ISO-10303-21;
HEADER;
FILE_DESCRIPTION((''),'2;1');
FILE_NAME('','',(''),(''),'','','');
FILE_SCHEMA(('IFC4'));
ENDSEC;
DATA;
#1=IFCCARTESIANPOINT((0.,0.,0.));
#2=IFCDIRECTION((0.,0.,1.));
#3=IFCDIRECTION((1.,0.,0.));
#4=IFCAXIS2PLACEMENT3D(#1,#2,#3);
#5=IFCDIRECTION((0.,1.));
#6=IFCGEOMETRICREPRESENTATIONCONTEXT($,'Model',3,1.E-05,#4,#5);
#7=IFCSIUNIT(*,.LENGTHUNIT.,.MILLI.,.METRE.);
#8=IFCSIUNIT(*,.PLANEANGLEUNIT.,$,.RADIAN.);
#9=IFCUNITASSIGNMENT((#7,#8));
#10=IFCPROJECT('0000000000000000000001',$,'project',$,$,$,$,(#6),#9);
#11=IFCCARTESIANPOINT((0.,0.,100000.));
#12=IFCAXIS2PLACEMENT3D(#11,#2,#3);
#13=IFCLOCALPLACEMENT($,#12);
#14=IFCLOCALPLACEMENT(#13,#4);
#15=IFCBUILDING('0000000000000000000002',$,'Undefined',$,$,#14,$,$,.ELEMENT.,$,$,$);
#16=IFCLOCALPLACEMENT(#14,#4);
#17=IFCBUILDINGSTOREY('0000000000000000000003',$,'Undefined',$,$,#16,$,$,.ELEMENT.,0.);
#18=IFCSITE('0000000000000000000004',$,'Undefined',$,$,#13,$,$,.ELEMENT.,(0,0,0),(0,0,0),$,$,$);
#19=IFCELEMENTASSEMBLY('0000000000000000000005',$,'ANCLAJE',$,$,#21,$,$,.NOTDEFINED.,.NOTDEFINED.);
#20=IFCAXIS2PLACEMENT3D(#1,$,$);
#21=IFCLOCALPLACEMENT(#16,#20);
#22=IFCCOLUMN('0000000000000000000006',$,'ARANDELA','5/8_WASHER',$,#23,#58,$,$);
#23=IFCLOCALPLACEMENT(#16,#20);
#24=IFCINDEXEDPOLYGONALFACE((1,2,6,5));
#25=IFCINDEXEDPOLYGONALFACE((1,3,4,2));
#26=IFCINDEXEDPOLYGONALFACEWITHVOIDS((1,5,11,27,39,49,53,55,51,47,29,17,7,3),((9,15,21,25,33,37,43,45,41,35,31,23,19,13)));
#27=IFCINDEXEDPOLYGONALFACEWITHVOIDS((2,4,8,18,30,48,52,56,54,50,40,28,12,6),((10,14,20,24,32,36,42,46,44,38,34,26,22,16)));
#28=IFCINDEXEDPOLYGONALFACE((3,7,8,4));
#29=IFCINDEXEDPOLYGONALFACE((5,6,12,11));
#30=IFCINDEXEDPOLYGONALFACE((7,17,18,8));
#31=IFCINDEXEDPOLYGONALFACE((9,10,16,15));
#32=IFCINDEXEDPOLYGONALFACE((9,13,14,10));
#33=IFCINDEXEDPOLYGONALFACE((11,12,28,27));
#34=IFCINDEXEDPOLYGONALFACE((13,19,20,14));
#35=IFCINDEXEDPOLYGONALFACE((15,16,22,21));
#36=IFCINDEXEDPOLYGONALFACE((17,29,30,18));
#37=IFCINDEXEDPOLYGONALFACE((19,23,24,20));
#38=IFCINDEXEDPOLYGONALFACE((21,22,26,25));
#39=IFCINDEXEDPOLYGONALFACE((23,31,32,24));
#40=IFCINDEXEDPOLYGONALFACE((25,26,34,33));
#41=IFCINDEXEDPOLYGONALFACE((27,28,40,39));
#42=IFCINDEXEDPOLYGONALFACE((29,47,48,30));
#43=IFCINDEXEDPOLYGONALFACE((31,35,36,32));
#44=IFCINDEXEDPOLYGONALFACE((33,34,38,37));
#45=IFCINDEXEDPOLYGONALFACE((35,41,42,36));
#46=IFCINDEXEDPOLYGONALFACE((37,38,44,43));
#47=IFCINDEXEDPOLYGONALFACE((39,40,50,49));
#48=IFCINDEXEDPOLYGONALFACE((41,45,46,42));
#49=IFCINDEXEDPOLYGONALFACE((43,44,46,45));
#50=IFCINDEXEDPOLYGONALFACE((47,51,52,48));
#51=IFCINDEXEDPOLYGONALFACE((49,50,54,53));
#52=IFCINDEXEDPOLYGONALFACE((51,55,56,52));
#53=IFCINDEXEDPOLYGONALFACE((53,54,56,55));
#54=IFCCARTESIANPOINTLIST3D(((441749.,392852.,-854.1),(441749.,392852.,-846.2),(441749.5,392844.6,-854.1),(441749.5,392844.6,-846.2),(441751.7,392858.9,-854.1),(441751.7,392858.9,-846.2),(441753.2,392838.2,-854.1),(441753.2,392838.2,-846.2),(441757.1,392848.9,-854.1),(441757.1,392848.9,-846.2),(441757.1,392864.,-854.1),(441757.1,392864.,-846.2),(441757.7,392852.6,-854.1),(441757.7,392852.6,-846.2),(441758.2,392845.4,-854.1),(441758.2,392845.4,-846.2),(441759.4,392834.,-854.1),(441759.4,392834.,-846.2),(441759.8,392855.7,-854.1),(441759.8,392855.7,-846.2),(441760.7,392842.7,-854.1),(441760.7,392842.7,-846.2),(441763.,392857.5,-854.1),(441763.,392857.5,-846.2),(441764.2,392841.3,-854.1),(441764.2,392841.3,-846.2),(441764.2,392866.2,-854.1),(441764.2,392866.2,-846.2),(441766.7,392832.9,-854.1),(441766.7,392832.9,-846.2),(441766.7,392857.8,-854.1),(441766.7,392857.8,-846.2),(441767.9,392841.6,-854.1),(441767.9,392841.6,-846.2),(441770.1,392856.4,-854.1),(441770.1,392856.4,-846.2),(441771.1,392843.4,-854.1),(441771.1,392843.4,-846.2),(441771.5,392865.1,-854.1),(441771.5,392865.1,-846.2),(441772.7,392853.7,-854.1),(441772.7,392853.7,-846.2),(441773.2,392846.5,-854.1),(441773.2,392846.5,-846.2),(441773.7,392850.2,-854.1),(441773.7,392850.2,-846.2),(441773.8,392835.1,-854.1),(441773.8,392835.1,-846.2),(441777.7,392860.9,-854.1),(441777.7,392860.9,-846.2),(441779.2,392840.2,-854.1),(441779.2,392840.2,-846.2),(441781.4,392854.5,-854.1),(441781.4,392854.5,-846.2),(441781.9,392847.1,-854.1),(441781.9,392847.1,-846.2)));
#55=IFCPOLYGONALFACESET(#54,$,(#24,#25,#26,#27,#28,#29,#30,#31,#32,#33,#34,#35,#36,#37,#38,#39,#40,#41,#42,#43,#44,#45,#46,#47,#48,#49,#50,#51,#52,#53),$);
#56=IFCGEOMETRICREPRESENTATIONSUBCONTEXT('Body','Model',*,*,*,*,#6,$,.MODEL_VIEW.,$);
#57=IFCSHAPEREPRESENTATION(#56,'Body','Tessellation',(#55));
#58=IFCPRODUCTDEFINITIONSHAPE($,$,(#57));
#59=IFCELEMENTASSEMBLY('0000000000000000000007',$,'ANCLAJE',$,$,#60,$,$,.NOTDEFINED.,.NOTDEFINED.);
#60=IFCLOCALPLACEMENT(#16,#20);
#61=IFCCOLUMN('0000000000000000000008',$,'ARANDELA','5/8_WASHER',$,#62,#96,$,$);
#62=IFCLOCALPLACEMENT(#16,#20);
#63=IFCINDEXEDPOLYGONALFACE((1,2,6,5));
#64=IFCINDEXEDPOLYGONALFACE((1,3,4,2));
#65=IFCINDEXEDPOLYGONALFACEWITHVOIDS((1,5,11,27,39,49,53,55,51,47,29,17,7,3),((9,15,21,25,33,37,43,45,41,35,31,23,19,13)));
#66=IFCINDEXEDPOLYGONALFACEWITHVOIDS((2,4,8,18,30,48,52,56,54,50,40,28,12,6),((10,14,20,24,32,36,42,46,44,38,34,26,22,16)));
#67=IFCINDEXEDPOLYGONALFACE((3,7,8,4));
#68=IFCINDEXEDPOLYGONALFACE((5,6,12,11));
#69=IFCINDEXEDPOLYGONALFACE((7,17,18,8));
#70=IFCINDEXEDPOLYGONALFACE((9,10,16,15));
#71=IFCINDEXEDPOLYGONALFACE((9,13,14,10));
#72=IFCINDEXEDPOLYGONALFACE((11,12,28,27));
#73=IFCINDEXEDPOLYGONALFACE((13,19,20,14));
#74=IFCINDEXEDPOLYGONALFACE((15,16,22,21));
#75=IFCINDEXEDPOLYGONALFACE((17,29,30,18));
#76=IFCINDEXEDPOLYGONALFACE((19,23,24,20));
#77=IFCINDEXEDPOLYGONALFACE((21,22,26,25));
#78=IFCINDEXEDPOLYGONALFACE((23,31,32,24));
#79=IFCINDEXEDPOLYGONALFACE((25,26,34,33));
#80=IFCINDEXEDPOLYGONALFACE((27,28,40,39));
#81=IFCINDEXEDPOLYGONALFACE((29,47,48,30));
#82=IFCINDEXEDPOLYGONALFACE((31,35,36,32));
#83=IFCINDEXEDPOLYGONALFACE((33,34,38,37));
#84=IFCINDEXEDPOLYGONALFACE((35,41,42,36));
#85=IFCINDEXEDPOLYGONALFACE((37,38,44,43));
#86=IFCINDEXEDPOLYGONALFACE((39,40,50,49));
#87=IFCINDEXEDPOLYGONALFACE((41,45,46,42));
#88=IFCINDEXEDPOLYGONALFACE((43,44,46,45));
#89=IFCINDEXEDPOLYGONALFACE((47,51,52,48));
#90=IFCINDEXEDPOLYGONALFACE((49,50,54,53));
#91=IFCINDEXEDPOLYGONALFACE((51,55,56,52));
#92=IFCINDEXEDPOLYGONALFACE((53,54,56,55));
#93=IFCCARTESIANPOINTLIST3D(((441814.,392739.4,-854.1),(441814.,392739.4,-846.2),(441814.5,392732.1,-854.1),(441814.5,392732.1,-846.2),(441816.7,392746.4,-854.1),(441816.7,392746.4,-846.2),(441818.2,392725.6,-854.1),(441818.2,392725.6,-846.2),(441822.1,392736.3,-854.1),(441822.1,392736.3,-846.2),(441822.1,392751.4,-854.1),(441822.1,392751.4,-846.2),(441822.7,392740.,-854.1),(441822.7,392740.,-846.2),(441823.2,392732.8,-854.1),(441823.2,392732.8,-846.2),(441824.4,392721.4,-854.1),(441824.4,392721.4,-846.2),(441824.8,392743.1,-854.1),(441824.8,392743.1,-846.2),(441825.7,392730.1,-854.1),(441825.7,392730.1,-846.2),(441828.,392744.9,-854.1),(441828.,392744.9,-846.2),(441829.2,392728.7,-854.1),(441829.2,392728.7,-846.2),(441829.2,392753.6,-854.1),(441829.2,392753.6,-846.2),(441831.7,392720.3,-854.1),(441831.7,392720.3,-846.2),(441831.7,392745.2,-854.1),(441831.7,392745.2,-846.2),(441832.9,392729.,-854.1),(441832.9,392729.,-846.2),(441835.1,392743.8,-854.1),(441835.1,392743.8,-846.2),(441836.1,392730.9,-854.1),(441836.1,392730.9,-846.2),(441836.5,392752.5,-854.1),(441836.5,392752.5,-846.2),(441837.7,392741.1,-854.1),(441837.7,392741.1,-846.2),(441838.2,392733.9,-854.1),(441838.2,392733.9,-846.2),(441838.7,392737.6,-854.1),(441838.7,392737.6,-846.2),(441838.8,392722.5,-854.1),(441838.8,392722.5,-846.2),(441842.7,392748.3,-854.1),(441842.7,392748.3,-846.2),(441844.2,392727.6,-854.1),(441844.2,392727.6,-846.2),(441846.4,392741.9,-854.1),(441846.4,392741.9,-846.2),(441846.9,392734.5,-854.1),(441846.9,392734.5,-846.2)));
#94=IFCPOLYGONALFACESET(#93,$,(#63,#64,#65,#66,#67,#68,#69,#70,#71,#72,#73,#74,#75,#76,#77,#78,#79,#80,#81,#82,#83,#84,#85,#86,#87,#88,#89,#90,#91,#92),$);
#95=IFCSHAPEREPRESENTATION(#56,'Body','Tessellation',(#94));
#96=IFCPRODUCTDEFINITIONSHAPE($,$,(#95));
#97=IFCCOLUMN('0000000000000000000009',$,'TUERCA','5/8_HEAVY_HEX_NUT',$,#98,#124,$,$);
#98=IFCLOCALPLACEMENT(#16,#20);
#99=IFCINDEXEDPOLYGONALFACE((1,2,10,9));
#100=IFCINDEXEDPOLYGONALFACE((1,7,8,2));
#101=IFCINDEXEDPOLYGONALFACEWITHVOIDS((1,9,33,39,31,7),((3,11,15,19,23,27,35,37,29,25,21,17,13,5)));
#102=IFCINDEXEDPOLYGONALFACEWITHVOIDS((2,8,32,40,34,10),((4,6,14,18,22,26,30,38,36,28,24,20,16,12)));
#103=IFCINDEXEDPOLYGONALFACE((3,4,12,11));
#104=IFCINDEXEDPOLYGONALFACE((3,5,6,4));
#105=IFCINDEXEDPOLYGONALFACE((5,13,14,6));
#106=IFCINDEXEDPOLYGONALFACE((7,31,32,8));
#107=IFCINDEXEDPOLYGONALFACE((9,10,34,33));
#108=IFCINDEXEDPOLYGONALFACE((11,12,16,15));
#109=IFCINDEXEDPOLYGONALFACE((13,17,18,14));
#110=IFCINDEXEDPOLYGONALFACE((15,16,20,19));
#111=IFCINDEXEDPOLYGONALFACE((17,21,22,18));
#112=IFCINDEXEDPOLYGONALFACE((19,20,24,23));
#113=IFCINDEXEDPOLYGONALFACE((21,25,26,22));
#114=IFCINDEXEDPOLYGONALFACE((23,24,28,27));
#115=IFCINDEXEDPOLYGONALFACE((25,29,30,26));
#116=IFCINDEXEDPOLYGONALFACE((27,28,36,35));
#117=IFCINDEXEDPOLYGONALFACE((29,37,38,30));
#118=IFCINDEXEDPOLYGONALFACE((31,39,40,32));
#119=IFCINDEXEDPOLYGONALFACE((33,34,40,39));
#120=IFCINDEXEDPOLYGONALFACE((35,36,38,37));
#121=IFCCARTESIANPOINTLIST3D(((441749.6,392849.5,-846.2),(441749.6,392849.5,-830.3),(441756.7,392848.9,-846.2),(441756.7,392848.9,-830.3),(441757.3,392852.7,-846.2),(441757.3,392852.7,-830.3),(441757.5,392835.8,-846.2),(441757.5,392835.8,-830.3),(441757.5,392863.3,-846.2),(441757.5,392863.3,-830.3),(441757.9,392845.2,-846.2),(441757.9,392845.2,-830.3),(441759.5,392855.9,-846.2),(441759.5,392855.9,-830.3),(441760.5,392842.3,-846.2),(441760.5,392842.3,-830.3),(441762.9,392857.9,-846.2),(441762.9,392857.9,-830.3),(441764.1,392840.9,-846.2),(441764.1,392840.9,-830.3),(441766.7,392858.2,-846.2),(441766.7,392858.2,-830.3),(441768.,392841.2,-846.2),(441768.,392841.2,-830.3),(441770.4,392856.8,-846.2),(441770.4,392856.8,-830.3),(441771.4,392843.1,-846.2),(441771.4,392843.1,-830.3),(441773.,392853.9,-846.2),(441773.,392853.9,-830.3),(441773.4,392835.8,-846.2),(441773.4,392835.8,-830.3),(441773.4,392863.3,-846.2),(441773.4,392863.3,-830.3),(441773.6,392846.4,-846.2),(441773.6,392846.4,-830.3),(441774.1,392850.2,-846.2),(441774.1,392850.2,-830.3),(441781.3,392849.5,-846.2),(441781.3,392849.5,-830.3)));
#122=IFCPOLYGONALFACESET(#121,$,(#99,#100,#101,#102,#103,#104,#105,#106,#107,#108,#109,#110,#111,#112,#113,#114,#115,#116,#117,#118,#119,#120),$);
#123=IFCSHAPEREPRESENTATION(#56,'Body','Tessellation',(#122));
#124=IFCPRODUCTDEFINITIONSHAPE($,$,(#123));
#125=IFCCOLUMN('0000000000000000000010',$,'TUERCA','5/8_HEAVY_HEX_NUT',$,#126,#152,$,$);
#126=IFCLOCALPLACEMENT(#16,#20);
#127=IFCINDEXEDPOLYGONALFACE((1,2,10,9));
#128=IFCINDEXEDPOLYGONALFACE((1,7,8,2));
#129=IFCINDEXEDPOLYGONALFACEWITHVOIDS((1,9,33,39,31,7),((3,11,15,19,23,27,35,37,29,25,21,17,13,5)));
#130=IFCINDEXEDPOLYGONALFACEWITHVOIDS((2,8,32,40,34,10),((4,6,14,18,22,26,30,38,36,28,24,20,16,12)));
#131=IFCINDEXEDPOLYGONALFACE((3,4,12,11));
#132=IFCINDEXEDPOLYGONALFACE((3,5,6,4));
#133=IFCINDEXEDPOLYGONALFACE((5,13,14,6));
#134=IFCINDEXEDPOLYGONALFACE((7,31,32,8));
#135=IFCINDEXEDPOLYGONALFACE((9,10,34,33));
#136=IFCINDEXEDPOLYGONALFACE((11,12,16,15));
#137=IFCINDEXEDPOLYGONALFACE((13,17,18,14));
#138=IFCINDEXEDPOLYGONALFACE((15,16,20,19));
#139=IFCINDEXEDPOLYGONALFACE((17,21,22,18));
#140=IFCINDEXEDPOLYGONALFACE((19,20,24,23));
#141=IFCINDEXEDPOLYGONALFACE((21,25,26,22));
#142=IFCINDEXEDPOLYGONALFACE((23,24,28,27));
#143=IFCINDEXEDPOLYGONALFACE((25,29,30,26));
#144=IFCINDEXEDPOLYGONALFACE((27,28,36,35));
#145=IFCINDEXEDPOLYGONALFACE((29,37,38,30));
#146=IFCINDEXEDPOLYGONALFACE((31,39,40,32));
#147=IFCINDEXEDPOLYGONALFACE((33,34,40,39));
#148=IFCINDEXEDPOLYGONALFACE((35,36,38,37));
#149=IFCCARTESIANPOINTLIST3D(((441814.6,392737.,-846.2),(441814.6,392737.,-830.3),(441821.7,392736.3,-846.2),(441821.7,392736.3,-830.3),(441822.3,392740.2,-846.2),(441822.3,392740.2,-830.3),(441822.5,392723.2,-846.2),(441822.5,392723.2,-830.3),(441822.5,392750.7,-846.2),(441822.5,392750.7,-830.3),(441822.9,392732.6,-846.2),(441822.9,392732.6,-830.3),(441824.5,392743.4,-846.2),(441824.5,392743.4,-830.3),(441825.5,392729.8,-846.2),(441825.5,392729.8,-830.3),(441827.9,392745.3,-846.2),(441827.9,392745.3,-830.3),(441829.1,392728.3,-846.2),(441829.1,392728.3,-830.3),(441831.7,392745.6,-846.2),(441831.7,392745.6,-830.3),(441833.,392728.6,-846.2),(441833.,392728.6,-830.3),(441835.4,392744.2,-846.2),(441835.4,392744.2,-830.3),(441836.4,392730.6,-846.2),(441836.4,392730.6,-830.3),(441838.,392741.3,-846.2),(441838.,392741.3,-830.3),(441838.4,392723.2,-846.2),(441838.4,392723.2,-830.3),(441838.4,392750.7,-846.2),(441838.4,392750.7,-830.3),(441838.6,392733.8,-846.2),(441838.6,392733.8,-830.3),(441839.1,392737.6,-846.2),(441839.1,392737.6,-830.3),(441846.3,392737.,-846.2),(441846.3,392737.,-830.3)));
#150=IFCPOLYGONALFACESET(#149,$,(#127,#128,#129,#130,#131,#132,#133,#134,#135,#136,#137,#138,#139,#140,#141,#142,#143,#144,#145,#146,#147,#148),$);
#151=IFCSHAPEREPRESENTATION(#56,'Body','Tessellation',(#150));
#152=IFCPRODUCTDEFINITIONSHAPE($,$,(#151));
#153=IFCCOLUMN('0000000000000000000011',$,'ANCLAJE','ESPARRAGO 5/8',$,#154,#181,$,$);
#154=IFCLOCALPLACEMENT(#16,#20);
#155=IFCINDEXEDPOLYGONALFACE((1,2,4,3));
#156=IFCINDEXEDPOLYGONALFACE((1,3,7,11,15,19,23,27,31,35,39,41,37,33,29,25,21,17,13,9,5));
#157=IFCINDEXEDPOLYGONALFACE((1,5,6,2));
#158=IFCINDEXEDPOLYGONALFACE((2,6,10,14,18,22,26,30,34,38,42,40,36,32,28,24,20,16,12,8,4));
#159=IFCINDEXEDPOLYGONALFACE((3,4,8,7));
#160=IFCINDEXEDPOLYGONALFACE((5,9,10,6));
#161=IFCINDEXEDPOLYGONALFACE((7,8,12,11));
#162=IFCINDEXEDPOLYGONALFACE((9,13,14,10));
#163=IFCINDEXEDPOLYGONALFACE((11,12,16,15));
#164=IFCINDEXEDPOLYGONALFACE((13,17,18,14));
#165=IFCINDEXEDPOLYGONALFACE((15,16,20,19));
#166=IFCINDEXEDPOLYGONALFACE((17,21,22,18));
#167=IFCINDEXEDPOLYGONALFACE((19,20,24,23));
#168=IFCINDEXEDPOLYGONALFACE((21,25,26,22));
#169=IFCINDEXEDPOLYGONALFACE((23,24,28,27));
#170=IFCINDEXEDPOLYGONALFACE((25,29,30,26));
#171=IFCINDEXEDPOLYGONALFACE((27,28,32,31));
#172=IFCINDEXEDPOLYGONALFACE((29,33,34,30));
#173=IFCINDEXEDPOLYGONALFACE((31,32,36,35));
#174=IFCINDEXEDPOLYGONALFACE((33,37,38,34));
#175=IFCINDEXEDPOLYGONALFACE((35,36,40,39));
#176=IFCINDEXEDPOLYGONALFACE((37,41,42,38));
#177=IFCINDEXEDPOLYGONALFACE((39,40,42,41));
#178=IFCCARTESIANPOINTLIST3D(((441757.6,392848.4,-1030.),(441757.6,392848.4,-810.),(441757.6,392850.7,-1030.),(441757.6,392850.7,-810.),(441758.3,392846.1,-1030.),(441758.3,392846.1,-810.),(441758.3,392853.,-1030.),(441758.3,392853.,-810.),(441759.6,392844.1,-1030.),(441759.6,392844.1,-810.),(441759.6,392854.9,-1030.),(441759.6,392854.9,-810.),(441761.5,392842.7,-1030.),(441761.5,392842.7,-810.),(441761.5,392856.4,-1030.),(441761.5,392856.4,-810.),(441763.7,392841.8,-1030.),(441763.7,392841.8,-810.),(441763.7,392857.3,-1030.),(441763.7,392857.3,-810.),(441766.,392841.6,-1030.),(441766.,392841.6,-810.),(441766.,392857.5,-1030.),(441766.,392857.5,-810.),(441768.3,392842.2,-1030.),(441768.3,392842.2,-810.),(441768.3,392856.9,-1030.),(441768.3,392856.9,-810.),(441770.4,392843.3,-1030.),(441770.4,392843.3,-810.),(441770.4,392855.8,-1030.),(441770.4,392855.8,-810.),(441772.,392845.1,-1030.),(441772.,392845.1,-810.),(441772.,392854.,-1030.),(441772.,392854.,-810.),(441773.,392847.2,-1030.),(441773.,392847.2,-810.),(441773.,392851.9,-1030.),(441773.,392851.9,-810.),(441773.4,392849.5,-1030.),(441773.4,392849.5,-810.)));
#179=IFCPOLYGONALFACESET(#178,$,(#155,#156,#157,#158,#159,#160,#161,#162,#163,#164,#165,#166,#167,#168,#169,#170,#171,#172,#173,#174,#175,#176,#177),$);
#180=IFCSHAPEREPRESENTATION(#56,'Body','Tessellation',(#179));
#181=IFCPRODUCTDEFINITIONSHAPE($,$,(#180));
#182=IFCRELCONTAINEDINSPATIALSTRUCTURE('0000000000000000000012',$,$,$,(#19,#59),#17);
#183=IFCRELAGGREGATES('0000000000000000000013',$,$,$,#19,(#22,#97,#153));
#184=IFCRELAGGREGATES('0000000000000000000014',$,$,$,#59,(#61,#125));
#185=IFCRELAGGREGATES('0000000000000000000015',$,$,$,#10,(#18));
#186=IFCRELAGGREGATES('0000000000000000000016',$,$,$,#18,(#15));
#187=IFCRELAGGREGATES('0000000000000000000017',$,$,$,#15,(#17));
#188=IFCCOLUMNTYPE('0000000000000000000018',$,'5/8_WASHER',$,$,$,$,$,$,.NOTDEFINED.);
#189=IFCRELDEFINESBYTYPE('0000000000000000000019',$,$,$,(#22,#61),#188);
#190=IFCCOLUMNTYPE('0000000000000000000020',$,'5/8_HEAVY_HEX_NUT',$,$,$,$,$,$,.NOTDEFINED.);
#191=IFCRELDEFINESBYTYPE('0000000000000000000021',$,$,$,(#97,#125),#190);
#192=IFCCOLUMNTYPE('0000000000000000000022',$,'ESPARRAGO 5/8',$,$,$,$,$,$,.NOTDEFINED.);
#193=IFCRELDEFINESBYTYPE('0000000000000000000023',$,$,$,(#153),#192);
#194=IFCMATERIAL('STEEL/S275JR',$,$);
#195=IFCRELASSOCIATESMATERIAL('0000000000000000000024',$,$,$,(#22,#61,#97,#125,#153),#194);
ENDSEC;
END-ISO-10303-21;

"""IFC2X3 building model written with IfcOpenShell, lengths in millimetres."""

from ifc_helpers import new_model, si_unit, direction, frame, origin_with_axes, origin_2d_with_axis, place, context, subcontext, project, spatial, polyline, circle, outline, extrude, material, type_object, element, aggregate, save


model = new_model("IFC2X3")

# Units and contexts
model_context = context("Model", 3, precision=1e-05, world=origin_with_axes(), true_north=direction((0.0, 1.0)))
body_context = subcontext(model_context, "Body", "Model", "MODEL_VIEW")
ifc_project = project(units=[si_unit("LENGTHUNIT", "METRE", prefix="MILLI"), si_unit("PLANEANGLEUNIT", "RADIAN")], contexts=[model_context])

# Site, building, storey
site_placement = place(None, frame((0.0, 0.0, 100000.0), z_axis=(0.0, 0.0, 1.0), x_axis=(1.0, 0.0, 0.0)))
site = spatial("IfcSite", under=ifc_project, at=site_placement, Name="Undefined", CompositionType="ELEMENT", RefLatitude=(0, 0, 0), RefLongitude=(0, 0, 0))
building_placement = place(site_placement, origin_with_axes())
building = spatial("IfcBuilding", under=site, at=building_placement, Name="Undefined", CompositionType="ELEMENT")
storey_placement = place(building_placement, origin_with_axes())
storey = spatial("IfcBuildingStorey", under=building, at=storey_placement, Name="Undefined", CompositionType="ELEMENT", Elevation=0.0)

# Element assemblies, columns
assembly_1_placement = place(storey_placement, origin_with_axes())
assembly_1 = element("IfcElementAssembly", 1, at=assembly_1_placement, inside=storey, Name="ANCLAJE", AssemblyPlace="NOTDEFINED", PredefinedType="NOTDEFINED")
ifc_material_1 = material(Name="STEEL/S275JR")
column_type_1 = type_object("IfcColumnType", Name="5/8_WASHER", PredefinedType="NOTDEFINED")
column_1_placement = place(assembly_1_placement, frame((441765.4, 392849.5, -846.2), z_axis=(0.0, 0.0, -1.0), x_axis=(-0.866025, -0.5, 0.0)))
column_1 = element("IfcColumn", 2, at=column_1_placement, type_object=column_type_1, material=ifc_material_1, Name="ARANDELA", Description="5/8_WASHER", context=body_context, shape_type="SweptSolid", body=[
    extrude(outline(polyline([(10.4, 13.0), (15.0, 7.2), (16.7, 0.0), (15.0, -7.2), (10.4, -13.0), (3.7, -16.3), (-3.7, -16.3), (-10.4, -13.0), (-15.0, -7.2), (-16.7, 0.0), (-15.0, 7.2), (-10.4, 13.0), (-3.7, 16.3), (3.7, 16.3), (10.4, 13.0)]), holes=[polyline([(6.5, -5.2), (8.1, -1.9), (8.1, 1.9), (6.5, 5.2), (3.6, 7.5), (0.0, 8.3), (-3.6, 7.5), (-6.5, 5.2), (-8.1, 1.9), (-8.1, -1.9), (-6.5, -5.2), (-3.6, -7.5), (0.0, -8.3), (3.6, -7.5), (6.5, -5.2)])]), frame((0.0, 0.0, 7.9), z_axis=(0.0, 0.0, -1.0), x_axis=(0.0, 1.0, 0.0)), (0.0, 0.0, 1.0), 7.9),
])
assembly_2_placement = place(storey_placement, origin_with_axes())
assembly_2 = element("IfcElementAssembly", 3, at=assembly_2_placement, inside=storey, Name="ANCLAJE", AssemblyPlace="NOTDEFINED", PredefinedType="NOTDEFINED")
column_2_placement = place(assembly_2_placement, frame((441830.4, 392737.0, -846.2), z_axis=(0.0, 0.0, -1.0), x_axis=(0.866025, 0.5, 0.0)))
column_2 = element("IfcColumn", 4, at=column_2_placement, type_object=column_type_1, material=ifc_material_1, Name="ARANDELA", Description="5/8_WASHER", context=body_context, shape_type="SweptSolid", body=[
    extrude(outline(polyline([(10.4, 13.0), (15.0, 7.2), (16.7, 0.0), (15.0, -7.2), (10.4, -13.0), (3.7, -16.3), (-3.7, -16.3), (-10.4, -13.0), (-15.0, -7.2), (-16.7, 0.0), (-15.0, 7.2), (-10.4, 13.0), (-3.7, 16.3), (3.7, 16.3), (10.4, 13.0)]), holes=[polyline([(6.5, -5.2), (8.1, -1.9), (8.1, 1.9), (6.5, 5.2), (3.6, 7.5), (0.0, 8.3), (-3.6, 7.5), (-6.5, 5.2), (-8.1, 1.9), (-8.1, -1.9), (-6.5, -5.2), (-3.6, -7.5), (0.0, -8.3), (3.6, -7.5), (6.5, -5.2)])]), frame((0.0, 0.0, 7.9), z_axis=(0.0, 0.0, -1.0), x_axis=(0.0, 1.0, 0.0)), (0.0, 0.0, 1.0), 7.9),
])

# Columns
column_type_2 = type_object("IfcColumnType", Name="5/8_HEAVY_HEX_NUT", PredefinedType="NOTDEFINED")
column_3_placement = place(assembly_1_placement, frame((441765.4, 392849.5, -830.3), z_axis=(0.0, 0.0, -1.0), x_axis=(-0.866025, -0.5, 0.0)))
column_3 = element("IfcColumn", 5, at=column_3_placement, type_object=column_type_2, material=ifc_material_1, Name="TUERCA", Description="5/8_HEAVY_HEX_NUT", context=body_context, shape_type="SweptSolid", body=[
    extrude(outline(polyline([(-7.9, -13.7), (-15.9, 0.0), (-7.9, 13.7), (7.9, 13.7), (15.9, 0.0), (7.9, -13.7), (-7.9, -13.7)]), holes=[polyline([(3.8, 7.9), (0.0, 8.7), (-3.8, 7.9), (-6.8, 5.4), (-8.5, 1.9), (-8.5, -1.9), (-6.8, -5.4), (-3.8, -7.9), (0.0, -8.7), (3.8, -7.9), (6.8, -5.4), (8.5, -1.9), (8.5, 1.9), (6.8, 5.4), (3.8, 7.9)])]), frame((0.0, 0.0, 15.9), z_axis=(0.0, 0.0, -1.0), x_axis=(0.0, 1.0, 0.0)), (0.0, 0.0, 1.0), 15.9),
])
column_4_placement = place(assembly_2_placement, frame((441830.4, 392737.0, -830.3), z_axis=(0.0, 0.0, -1.0), x_axis=(0.866025, 0.5, 0.0)))
column_4 = element("IfcColumn", 6, at=column_4_placement, type_object=column_type_2, material=ifc_material_1, Name="TUERCA", Description="5/8_HEAVY_HEX_NUT", context=body_context, shape_type="SweptSolid", body=[
    extrude(outline(polyline([(-7.9, -13.7), (-15.9, 0.0), (-7.9, 13.7), (7.9, 13.7), (15.9, 0.0), (7.9, -13.7), (-7.9, -13.7)]), holes=[polyline([(3.8, 7.9), (0.0, 8.7), (-3.8, 7.9), (-6.8, 5.4), (-8.5, 1.9), (-8.5, -1.9), (-6.8, -5.4), (-3.8, -7.9), (0.0, -8.7), (3.8, -7.9), (6.8, -5.4), (8.5, -1.9), (8.5, 1.9), (6.8, 5.4), (3.8, 7.9)])]), frame((0.0, 0.0, 15.9), z_axis=(0.0, 0.0, -1.0), x_axis=(0.0, 1.0, 0.0)), (0.0, 0.0, 1.0), 15.9),
])
column_type_3 = type_object("IfcColumnType", Name="ESPARRAGO 5/8", PredefinedType="NOTDEFINED")
column_5_placement = place(assembly_1_placement, frame((441765.4, 392849.5, -810.0), z_axis=(0.0, 0.0, -1.0), x_axis=(-0.866025, -0.5, 0.0)))
column_5 = element("IfcColumn", 7, at=column_5_placement, type_object=column_type_3, material=ifc_material_1, Name="ANCLAJE", Description="ESPARRAGO 5/8", context=body_context, shape_type="SweptSolid", body=[
    extrude(circle(Radius=7.9, at=origin_2d_with_axis()), frame((0.0, 0.0, 220.0), z_axis=(0.0, 0.0, -1.0), x_axis=(0.0, 1.0, 0.0)), (0.0, 0.0, 1.0), 220.0),
])
aggregate(assembly_1, [column_1, column_3, column_5])
aggregate(assembly_2, [column_2, column_4])

save(model, "model.ifc")
